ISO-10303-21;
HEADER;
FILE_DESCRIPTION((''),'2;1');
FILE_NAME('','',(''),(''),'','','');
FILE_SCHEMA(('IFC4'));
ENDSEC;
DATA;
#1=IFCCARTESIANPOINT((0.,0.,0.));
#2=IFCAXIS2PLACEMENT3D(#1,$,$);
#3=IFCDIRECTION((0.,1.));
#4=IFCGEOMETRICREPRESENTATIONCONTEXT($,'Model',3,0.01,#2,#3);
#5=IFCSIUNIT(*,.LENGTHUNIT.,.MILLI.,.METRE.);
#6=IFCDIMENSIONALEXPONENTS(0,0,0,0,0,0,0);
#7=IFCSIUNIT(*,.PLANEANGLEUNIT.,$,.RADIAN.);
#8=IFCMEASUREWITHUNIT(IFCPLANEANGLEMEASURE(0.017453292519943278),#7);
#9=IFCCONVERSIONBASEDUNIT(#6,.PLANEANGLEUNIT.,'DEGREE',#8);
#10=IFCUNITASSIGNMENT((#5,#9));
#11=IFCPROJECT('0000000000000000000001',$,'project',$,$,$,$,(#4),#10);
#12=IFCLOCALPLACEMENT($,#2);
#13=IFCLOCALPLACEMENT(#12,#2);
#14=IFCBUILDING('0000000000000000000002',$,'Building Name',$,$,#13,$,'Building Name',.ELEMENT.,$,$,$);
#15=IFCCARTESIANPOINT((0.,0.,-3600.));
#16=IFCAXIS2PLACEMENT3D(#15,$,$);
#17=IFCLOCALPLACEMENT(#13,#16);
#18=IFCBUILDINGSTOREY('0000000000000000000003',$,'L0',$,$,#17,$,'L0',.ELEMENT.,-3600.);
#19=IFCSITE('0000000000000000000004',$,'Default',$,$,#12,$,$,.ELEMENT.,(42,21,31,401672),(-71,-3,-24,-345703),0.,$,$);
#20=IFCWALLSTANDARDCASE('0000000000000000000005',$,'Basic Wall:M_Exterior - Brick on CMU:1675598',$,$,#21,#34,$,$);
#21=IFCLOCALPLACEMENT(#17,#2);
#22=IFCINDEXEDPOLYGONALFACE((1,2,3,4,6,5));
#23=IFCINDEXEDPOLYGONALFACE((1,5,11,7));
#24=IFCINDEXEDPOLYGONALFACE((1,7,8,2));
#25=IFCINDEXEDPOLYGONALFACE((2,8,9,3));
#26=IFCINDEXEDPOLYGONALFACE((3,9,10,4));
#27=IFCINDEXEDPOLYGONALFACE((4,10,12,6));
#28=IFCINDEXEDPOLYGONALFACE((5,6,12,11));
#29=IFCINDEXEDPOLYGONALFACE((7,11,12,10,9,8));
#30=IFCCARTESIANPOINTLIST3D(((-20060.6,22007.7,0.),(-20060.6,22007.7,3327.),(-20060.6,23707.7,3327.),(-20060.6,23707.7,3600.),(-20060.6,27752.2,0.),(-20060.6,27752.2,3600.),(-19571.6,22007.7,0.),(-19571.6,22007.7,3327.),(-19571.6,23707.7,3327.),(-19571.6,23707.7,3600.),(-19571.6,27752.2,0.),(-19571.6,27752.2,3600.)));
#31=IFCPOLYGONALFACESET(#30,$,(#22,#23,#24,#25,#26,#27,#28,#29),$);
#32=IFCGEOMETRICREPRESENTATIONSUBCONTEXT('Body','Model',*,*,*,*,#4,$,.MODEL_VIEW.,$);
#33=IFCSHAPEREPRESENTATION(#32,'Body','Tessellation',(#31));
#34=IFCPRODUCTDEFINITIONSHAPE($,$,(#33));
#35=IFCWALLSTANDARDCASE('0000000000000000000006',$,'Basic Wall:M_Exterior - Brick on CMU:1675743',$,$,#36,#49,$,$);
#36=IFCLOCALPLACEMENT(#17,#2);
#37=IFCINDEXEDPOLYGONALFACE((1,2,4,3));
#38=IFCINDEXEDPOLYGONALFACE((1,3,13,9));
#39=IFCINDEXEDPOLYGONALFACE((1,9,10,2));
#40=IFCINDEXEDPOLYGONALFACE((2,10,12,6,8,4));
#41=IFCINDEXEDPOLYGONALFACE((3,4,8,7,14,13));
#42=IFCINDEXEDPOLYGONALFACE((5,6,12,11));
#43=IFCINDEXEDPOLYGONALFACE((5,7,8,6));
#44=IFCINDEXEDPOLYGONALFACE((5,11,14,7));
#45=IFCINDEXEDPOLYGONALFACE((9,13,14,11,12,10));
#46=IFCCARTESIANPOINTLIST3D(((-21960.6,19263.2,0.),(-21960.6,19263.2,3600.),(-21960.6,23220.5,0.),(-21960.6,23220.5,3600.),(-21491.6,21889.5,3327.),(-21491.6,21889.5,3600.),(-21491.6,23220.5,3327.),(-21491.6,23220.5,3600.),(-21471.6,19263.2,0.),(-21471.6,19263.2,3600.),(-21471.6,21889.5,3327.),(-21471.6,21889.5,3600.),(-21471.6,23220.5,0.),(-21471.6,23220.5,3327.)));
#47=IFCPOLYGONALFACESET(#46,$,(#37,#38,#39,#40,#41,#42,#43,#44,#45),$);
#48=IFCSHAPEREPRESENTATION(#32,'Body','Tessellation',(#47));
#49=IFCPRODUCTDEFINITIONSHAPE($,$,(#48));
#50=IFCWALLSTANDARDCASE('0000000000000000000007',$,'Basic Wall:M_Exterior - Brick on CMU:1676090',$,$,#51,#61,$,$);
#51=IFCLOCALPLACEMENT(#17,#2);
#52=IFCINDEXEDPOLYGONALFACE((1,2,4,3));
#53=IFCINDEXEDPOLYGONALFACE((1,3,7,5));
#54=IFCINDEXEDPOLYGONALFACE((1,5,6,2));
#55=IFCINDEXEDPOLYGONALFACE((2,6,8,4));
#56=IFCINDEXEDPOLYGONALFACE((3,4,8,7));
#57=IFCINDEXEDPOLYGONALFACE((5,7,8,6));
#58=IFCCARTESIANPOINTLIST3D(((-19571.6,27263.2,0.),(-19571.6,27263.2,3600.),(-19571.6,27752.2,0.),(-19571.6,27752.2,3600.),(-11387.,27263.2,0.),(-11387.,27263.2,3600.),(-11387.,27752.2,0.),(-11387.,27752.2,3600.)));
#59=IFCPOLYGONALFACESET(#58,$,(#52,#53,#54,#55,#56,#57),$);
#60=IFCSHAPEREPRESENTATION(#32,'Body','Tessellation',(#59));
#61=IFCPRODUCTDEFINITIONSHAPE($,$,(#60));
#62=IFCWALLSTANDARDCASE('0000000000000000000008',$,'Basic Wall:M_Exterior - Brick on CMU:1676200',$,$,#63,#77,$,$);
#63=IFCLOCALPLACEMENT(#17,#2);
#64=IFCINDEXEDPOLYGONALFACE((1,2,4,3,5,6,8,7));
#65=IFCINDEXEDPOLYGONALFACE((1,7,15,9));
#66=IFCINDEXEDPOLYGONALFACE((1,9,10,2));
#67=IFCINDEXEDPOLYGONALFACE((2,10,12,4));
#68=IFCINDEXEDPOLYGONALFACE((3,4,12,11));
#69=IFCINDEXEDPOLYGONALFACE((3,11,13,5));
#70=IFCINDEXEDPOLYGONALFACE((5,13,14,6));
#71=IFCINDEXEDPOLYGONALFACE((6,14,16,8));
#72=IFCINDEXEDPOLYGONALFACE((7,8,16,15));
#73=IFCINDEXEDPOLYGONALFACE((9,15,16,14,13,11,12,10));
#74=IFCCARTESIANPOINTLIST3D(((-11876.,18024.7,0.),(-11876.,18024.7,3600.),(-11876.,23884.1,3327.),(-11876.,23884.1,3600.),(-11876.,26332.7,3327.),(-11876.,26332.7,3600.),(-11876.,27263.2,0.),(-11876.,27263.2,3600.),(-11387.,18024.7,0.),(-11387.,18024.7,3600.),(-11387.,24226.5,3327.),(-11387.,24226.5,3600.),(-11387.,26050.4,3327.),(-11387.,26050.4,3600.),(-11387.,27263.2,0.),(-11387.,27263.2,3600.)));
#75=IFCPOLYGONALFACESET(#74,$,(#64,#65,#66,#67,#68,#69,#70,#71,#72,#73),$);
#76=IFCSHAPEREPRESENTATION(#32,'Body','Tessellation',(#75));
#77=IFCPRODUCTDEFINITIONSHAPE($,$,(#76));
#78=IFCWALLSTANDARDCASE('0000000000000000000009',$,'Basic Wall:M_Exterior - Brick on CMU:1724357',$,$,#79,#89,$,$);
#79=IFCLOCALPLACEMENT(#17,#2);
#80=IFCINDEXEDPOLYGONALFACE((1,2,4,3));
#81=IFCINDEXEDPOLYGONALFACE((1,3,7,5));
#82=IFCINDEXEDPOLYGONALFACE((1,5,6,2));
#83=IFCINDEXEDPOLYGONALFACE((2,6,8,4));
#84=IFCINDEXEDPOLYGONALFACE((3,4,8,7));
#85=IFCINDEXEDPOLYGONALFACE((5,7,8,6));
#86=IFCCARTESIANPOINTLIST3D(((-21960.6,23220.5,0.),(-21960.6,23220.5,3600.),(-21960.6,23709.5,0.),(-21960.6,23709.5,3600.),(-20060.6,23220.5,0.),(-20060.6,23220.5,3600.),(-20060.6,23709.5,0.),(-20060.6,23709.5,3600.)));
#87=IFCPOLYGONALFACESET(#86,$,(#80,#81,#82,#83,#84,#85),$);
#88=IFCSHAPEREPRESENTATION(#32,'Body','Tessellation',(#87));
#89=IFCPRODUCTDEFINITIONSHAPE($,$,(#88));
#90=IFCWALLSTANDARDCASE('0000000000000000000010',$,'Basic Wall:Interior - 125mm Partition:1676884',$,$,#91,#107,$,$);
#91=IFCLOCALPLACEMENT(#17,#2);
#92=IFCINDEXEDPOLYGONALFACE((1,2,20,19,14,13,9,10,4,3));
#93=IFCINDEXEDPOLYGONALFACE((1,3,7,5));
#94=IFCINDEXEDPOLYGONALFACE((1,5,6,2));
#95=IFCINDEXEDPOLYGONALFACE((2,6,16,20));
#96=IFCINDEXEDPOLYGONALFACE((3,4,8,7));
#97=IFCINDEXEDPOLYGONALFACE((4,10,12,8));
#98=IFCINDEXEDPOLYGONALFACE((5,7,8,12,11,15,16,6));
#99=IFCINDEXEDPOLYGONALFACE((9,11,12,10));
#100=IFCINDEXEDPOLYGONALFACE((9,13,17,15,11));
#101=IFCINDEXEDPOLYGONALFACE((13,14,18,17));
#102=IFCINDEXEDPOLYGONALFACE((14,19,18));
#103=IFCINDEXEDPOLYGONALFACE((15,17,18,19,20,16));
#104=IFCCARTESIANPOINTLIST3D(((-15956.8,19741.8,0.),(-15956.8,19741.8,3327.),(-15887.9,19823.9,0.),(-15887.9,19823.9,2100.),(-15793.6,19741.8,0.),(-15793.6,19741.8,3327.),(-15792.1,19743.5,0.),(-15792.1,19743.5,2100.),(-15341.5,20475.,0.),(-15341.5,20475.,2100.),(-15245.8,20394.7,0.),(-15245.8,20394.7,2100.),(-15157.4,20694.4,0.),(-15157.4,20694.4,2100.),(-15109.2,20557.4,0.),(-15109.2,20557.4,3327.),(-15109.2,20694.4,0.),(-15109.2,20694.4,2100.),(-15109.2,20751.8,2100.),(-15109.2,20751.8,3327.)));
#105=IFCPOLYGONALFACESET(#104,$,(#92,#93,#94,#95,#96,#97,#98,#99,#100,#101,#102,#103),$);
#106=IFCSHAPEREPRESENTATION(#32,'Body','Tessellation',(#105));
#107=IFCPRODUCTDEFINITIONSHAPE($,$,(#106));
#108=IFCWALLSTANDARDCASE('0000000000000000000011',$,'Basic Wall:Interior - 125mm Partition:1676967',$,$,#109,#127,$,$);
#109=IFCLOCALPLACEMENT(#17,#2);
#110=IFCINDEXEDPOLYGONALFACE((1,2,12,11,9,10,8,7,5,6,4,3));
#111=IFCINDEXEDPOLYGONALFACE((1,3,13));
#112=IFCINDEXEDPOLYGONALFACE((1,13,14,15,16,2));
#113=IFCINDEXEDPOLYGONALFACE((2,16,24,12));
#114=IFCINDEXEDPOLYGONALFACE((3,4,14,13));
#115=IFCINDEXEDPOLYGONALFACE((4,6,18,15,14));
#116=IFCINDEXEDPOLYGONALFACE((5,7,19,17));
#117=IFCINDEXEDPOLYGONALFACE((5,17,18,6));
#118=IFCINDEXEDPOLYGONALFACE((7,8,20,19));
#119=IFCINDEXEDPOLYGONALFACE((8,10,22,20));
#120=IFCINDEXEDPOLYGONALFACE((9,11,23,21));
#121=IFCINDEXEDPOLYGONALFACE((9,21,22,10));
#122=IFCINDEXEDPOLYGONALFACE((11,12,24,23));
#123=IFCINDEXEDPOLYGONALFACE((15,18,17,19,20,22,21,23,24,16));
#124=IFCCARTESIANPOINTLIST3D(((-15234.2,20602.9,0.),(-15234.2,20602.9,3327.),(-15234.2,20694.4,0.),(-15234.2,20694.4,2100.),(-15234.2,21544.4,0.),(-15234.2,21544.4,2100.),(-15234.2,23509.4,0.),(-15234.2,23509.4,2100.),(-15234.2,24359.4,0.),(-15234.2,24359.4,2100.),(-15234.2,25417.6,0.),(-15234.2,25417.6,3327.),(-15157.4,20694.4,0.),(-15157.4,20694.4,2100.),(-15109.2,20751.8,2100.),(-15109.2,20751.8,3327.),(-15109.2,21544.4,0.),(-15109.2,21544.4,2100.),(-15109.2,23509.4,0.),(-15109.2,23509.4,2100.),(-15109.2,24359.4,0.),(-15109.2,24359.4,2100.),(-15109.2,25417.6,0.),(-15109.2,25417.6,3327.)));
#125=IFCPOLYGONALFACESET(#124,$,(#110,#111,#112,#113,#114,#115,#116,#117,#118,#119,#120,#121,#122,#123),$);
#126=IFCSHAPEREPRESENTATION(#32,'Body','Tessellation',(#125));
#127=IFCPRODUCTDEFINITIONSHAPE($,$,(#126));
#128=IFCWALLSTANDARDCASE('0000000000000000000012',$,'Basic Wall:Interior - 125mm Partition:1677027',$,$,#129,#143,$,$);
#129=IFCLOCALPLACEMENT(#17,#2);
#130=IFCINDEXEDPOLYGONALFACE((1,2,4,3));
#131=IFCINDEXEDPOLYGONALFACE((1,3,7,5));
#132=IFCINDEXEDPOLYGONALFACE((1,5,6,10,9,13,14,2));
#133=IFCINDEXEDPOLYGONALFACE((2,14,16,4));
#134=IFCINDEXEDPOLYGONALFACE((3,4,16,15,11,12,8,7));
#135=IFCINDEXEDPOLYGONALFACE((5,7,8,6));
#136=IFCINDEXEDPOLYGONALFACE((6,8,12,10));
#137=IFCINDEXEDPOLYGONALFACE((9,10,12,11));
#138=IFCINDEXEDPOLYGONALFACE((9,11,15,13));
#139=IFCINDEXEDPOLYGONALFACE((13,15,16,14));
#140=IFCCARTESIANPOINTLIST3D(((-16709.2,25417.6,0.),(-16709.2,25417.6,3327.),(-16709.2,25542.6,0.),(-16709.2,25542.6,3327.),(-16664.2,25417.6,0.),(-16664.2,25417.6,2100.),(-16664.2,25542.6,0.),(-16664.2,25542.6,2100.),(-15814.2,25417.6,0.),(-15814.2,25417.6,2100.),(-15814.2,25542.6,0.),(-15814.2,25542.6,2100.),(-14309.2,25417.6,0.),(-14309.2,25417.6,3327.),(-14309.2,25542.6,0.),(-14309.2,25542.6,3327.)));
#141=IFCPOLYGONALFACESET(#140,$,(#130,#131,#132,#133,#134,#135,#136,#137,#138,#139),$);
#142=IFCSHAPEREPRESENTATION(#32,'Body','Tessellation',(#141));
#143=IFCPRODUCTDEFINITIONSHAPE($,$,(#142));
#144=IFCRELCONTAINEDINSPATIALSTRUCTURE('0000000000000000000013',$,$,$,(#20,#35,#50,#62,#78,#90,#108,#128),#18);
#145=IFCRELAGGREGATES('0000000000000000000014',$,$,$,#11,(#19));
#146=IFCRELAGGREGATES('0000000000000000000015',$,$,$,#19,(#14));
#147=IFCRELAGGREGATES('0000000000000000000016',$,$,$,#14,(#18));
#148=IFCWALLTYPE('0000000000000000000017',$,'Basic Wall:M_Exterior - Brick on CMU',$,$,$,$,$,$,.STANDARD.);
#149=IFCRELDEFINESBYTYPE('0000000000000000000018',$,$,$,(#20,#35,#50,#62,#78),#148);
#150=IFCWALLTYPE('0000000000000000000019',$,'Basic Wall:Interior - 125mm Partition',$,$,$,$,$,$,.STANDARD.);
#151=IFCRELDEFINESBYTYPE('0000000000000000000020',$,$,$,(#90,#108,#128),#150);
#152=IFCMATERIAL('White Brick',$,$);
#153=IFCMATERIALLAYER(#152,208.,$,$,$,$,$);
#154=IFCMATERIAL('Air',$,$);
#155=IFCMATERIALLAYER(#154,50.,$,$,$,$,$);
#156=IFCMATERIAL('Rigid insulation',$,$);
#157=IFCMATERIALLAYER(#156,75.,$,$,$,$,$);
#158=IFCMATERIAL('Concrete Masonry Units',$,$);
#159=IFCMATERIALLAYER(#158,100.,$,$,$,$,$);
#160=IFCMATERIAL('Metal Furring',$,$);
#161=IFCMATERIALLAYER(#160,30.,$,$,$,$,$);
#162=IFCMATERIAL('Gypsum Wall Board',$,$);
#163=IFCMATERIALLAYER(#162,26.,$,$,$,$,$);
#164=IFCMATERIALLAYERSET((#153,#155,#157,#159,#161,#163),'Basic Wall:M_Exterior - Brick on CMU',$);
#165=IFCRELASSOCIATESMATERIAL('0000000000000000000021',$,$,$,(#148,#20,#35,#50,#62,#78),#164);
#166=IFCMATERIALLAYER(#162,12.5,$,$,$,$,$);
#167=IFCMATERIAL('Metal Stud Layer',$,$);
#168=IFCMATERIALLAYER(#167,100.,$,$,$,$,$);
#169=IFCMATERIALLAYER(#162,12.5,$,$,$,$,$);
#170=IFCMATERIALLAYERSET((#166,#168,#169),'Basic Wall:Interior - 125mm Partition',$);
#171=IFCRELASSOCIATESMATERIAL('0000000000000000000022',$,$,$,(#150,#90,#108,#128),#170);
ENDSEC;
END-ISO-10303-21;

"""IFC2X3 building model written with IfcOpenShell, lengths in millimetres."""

from ifc_helpers import new_model, entity, si_unit, converted_unit, direction, frame, frame_2d, origin, place, context, subcontext, project, spatial, polyline, rectangle, outline, extrude, clip, bounded_halfspace, material, layer, layer_set, layer_usage, type_object, element, save


model = new_model("IFC2X3")

# Units and contexts
model_context = context("Model", 3, precision=0.01, world=origin(), true_north=direction((0.0, 1.0)))
body_context = subcontext(model_context, "Body", "Model", "MODEL_VIEW")
ifc_project = project(units=[si_unit("LENGTHUNIT", "METRE", prefix="MILLI"), converted_unit("PLANEANGLEUNIT", "DEGREE", entity("IfcPlaneAngleMeasure", 0.017453292519943278), si_unit("PLANEANGLEUNIT", "RADIAN"), dimensions=[0, 0, 0, 0, 0, 0, 0])], contexts=[model_context])

# Site, building, storey
site_placement = place(None, origin())
site = spatial("IfcSite", under=ifc_project, at=site_placement, Name="Default", CompositionType="ELEMENT", RefLatitude=(42, 21, 31, 401672), RefLongitude=(-71, -3, -24, -345703), RefElevation=0.0)
building_placement = place(site_placement, origin())
building = spatial("IfcBuilding", under=site, at=building_placement, Name="Building Name", LongName="Building Name", CompositionType="ELEMENT")
storey_placement = place(building_placement, frame((0.0, 0.0, -3600.0)))
storey = spatial("IfcBuildingStorey", under=building, at=storey_placement, Name="L0", LongName="L0", CompositionType="ELEMENT", Elevation=-3600.0)

# Walls
ifc_material_1 = material(Name="White Brick")
ifc_layer_1 = layer(ifc_material_1, 208.0)
ifc_material_2 = material(Name="Air")
ifc_layer_2 = layer(ifc_material_2, 50.0)
ifc_material_3 = material(Name="Rigid insulation")
ifc_layer_3 = layer(ifc_material_3, 75.0)
ifc_material_4 = material(Name="Concrete Masonry Units")
ifc_layer_4 = layer(ifc_material_4, 100.0)
ifc_material_5 = material(Name="Metal Furring")
ifc_layer_5 = layer(ifc_material_5, 30.0)
ifc_material_6 = material(Name="Gypsum Wall Board")
ifc_layer_6 = layer(ifc_material_6, 26.0)
ifc_layer_set_1 = layer_set([ifc_layer_1, ifc_layer_2, ifc_layer_3, ifc_layer_4, ifc_layer_5, ifc_layer_6], Name="Basic Wall:M_Exterior - Brick on CMU")
ifc_layer_usage_1 = layer_usage(ifc_layer_set_1, "AXIS2", "NEGATIVE", 244.5)
wall_type_1 = type_object("IfcWallType", Name="Basic Wall:M_Exterior - Brick on CMU", PredefinedType="STANDARD", material=ifc_layer_set_1)
wall_1_placement = place(storey_placement, frame((-19816.1, 27752.2, 0.0), z_axis=(0.0, 0.0, 1.0), x_axis=(0.0, -1.0, 0.0)))
element("IfcWallStandardCase", 1, at=wall_1_placement, inside=storey, type_object=wall_type_1, material=ifc_layer_usage_1, Name="Basic Wall:M_Exterior - Brick on CMU:1675598", context=body_context, shape_type="Clipping", body=[
    clip(extrude(rectangle(XDim=5744.5, YDim=489.0, at=frame_2d((2872.3, 0.0), x_axis=(-1.0, 0.0))), origin(), (0.0, 0.0, 1.0), 3600.0), bounded_halfspace(frame((4044.5, -244.5, 3327.0), z_axis=(0.0, 0.0, -1.0), x_axis=(-1.0, 0.0, 0.0)), True, frame((4044.5, -244.5, 3327.0)), polyline([(0.0, 0.0), (1700.0, 0.0), (1700.0, 125.0), (1700.0, 489.0), (418.0, 489.0), (293.0, 489.0), (0.0, 489.0), (0.0, 0.0)]))),
])
ifc_layer_usage_2 = layer_usage(ifc_layer_set_1, "AXIS2", "NEGATIVE", 244.5)
wall_2_placement = place(storey_placement, frame((-21716.1, 23220.5, 0.0), z_axis=(0.0, 0.0, 1.0), x_axis=(0.0, -1.0, 0.0)))
element("IfcWallStandardCase", 2, at=wall_2_placement, inside=storey, type_object=wall_type_1, material=ifc_layer_usage_2, Name="Basic Wall:M_Exterior - Brick on CMU:1675743", context=body_context, shape_type="Clipping", body=[
    clip(extrude(rectangle(XDim=3957.3, YDim=489.0, at=frame_2d((1978.7, 0.0), x_axis=(-1.0, 0.0))), origin(), (0.0, 0.0, 1.0), 3600.0), bounded_halfspace(frame((1331.0, 224.5, 3327.0), z_axis=(0.0, 0.0, -1.0), x_axis=(-1.0, 0.0, 0.0)), True, frame((1331.0, 224.5, 3327.0)), polyline([(0.0, 0.0), (0.0, 20.0), (-1331.0, 20.0), (-1331.0, 0.0), (0.0, 0.0)]))),
])
ifc_layer_usage_3 = layer_usage(ifc_layer_set_1, "AXIS2", "NEGATIVE", 244.5)
wall_3_placement = place(storey_placement, frame((-19571.6, 27507.7, 0.0)))
element("IfcWallStandardCase", 3, at=wall_3_placement, inside=storey, type_object=wall_type_1, material=ifc_layer_usage_3, Name="Basic Wall:M_Exterior - Brick on CMU:1676090", context=body_context, shape_type="SweptSolid", body=[
    extrude(rectangle(XDim=8184.6, YDim=489.0, at=frame_2d((4092.3, 0.0), x_axis=(-1.0, 0.0))), origin(), (0.0, 0.0, 1.0), 3600.0),
])
ifc_layer_usage_4 = layer_usage(ifc_layer_set_1, "AXIS2", "NEGATIVE", 244.5)
wall_4_placement = place(storey_placement, frame((-11631.5, 27263.2, 0.0), z_axis=(0.0, 0.0, 1.0), x_axis=(0.0, -1.0, 0.0)))
element("IfcWallStandardCase", 4, at=wall_4_placement, inside=storey, type_object=wall_type_1, material=ifc_layer_usage_4, Name="Basic Wall:M_Exterior - Brick on CMU:1676200", context=body_context, shape_type="Clipping", body=[
    clip(extrude(rectangle(XDim=9238.5, YDim=489.0, at=frame_2d((4619.3, 0.0), x_axis=(-1.0, 0.0))), origin(), (0.0, 0.0, 1.0), 3600.0), bounded_halfspace(frame((930.4, -244.5, 3327.0), z_axis=(0.0, 0.0, -1.0), x_axis=(-1.0, 0.0, 0.0)), True, frame((930.4, -244.5, 3327.0)), polyline([(0.0, 0.0), (2448.6, 0.0), (2106.2, 489.0), (282.3, 489.0), (0.0, 0.0)]))),
])
ifc_layer_usage_5 = layer_usage(ifc_layer_set_1, "AXIS2", "POSITIVE", -244.5)
wall_5_placement = place(storey_placement, frame((-20060.6, 23465.0, 0.0), z_axis=(0.0, 0.0, 1.0), x_axis=(-1.0, 0.0, 0.0)))
element("IfcWallStandardCase", 5, at=wall_5_placement, inside=storey, type_object=wall_type_1, material=ifc_layer_usage_5, Name="Basic Wall:M_Exterior - Brick on CMU:1724357", context=body_context, shape_type="SweptSolid", body=[
    extrude(rectangle(XDim=1900.0, YDim=489.0, at=frame_2d((950.0, 0.0), x_axis=(-1.0, 0.0))), origin(), (0.0, 0.0, 1.0), 3600.0),
])

# Walls, openings
ifc_layer_7 = layer(ifc_material_6, 12.5)
ifc_material_7 = material(Name="Metal Stud Layer")
ifc_layer_8 = layer(ifc_material_7, 100.0)
ifc_layer_9 = layer(ifc_material_6, 12.5)
ifc_layer_set_2 = layer_set([ifc_layer_7, ifc_layer_8, ifc_layer_9], Name="Basic Wall:Interior - 125mm Partition")
ifc_layer_usage_6 = layer_usage(ifc_layer_set_2, "AXIS2", "NEGATIVE", 62.5)
wall_type_2 = type_object("IfcWallType", Name="Basic Wall:Interior - 125mm Partition", PredefinedType="STANDARD", material=ifc_layer_set_2)
wall_6_placement = place(storey_placement, frame((-15908.9, 19701.6, 0.0), z_axis=(0.0, 0.0, 1.0), x_axis=(0.642788, 0.766044, 0.0)))
wall_6 = element("IfcWallStandardCase", 6, at=wall_6_placement, inside=storey, type_object=wall_type_2, material=ifc_layer_usage_6, Name="Basic Wall:Interior - 125mm Partition:1676884", context=body_context, shape_type="Clipping", body=[
    clip(extrude(outline(polyline([(104.9, -62.5), (1117.7, -62.5), (1169.6, -62.5), (1234.9, -7.7), (1318.6, 62.5), (1124.1, 62.5), (0.0, 62.5), (104.9, -62.5)])), origin(), (0.0, 0.0, 1.0), 3327.0), bounded_halfspace(frame((104.9, -62.5, 3327.0), z_axis=(0.0, 0.0, -1.0), x_axis=(0.766044, 0.642788, 0.0)), True, frame((104.9, -62.5, 3327.0)), polyline([(0.0, 0.0), (1012.8, 0.0), (1064.7, 0.0), (1130.0, 54.8), (1213.7, 125.0), (1019.2, 125.0), (-104.9, 125.0), (0.0, 0.0)]))),
])
opening_1_placement = place(wall_6_placement, origin())
element("IfcOpeningElement", 7, at=opening_1_placement, cuts=wall_6, ObjectType="Opening", context=body_context, shape_type="SweptSolid", body=[
    extrude(rectangle(XDim=2100.0, YDim=850.0, at=frame_2d((0.0, 0.0), x_axis=(1.0, 0.0))), frame((1600.1, 298.8, 1050.0), z_axis=(-0.642788, 0.766044, 0.0), x_axis=(0.0, 0.0, 1.0)), (0.0, 0.0, 1.0), 125.0),
])
opening_2_placement = place(wall_6_placement, frame((957.2, 62.5, 0.0)))
element("IfcOpeningElement", 8, at=opening_2_placement, cuts=wall_6, ObjectType="Opening", context=body_context, shape_type="SweptSolid", body=[
    extrude(rectangle(XDim=2100.0, YDim=850.0, at=frame_2d((1050.0, 425.0), x_axis=(1.0, 0.0))), frame((0.0, 0.0, 0.0), z_axis=(0.0, -1.0, 0.0), x_axis=(0.0, 0.0, 1.0)), (0.0, 0.0, 1.0), 125.0),
])
ifc_layer_usage_7 = layer_usage(ifc_layer_set_2, "AXIS2", "NEGATIVE", 62.5)
wall_7_placement = place(storey_placement, frame((-15171.7, 20602.9, 0.0), z_axis=(0.0, 0.0, 1.0), x_axis=(0.0, 1.0, 0.0)))
wall_7 = element("IfcWallStandardCase", 9, at=wall_7_placement, inside=storey, type_object=wall_type_2, material=ifc_layer_usage_7, Name="Basic Wall:Interior - 125mm Partition:1676967", context=body_context, shape_type="Clipping", body=[
    clip(extrude(outline(polyline([(149.0, -62.5), (2721.6, -62.5), (2846.6, -62.5), (4814.8, -62.5), (4814.8, 62.5), (0.0, 62.5), (149.0, -62.5)])), origin(), (0.0, 0.0, 1.0), 3327.0), bounded_halfspace(frame((149.0, -62.5, 3327.0), z_axis=(0.0, 0.0, -1.0), x_axis=(1.0, 0.0, 0.0)), True, frame((149.0, -62.5, 3327.0)), polyline([(0.0, 0.0), (2572.6, 0.0), (2697.6, 0.0), (4665.8, 0.0), (4665.8, 125.0), (-149.0, 125.0), (0.0, 0.0)]))),
])
opening_3_placement = place(wall_7_placement, frame((3756.6, 62.5, 0.0)))
element("IfcOpeningElement", 10, at=opening_3_placement, cuts=wall_7, ObjectType="Opening", context=body_context, shape_type="SweptSolid", body=[
    extrude(rectangle(XDim=2100.0, YDim=850.0, at=frame_2d((1050.0, 425.0), x_axis=(1.0, 0.0))), frame((0.0, 0.0, 0.0), z_axis=(0.0, -1.0, 0.0), x_axis=(0.0, 0.0, 1.0)), (0.0, 0.0, 1.0), 125.0),
])
opening_4_placement = place(wall_7_placement, frame((941.6, 62.5, 0.0)))
element("IfcOpeningElement", 11, at=opening_4_placement, cuts=wall_7, ObjectType="Opening", context=body_context, shape_type="SweptSolid", body=[
    extrude(rectangle(XDim=2100.0, YDim=850.0, at=frame_2d((1050.0, 425.0), x_axis=(1.0, 0.0))), frame((0.0, 0.0, 0.0), z_axis=(0.0, -1.0, 0.0), x_axis=(0.0, 0.0, 1.0)), (0.0, 0.0, 1.0), 125.0),
])

# Wall, opening
ifc_layer_usage_8 = layer_usage(ifc_layer_set_2, "AXIS2", "NEGATIVE", 62.5)
wall_8_placement = place(storey_placement, frame((-14309.2, 25480.1, 0.0), z_axis=(0.0, 0.0, 1.0), x_axis=(-1.0, 0.0, 0.0)))
wall_8 = element("IfcWallStandardCase", 12, at=wall_8_placement, inside=storey, type_object=wall_type_2, material=ifc_layer_usage_8, Name="Basic Wall:Interior - 125mm Partition:1677027", context=body_context, shape_type="Clipping", body=[
    clip(extrude(rectangle(XDim=2400.0, YDim=125.0, at=frame_2d((1200.0, 0.0), x_axis=(1.0, 0.0))), origin(), (0.0, 0.0, 1.0), 3327.0), bounded_halfspace(frame((0.0, -62.5, 3327.0), z_axis=(0.0, 0.0, -1.0), x_axis=(0.0, -1.0, 0.0)), True, frame((0.0, -62.5, 3327.0)), polyline([(0.0, 0.0), (125.0, 0.0), (2400.0, 0.0), (2400.0, 125.0), (925.0, 125.0), (800.0, 125.0), (0.0, 125.0), (0.0, 0.0)]))),
])
opening_5_placement = place(wall_8_placement, frame((2355.0, 62.5, 0.0)))
element("IfcOpeningElement", 13, at=opening_5_placement, cuts=wall_8, ObjectType="Opening", context=body_context, shape_type="SweptSolid", body=[
    extrude(rectangle(XDim=2100.0, YDim=850.0, at=frame_2d((1050.0, 425.0), x_axis=(1.0, 0.0))), frame((0.0, 0.0, 0.0), z_axis=(0.0, -1.0, 0.0), x_axis=(0.0, 0.0, 1.0)), (0.0, 0.0, 1.0), 125.0),
])

save(model, "model.ifc")
